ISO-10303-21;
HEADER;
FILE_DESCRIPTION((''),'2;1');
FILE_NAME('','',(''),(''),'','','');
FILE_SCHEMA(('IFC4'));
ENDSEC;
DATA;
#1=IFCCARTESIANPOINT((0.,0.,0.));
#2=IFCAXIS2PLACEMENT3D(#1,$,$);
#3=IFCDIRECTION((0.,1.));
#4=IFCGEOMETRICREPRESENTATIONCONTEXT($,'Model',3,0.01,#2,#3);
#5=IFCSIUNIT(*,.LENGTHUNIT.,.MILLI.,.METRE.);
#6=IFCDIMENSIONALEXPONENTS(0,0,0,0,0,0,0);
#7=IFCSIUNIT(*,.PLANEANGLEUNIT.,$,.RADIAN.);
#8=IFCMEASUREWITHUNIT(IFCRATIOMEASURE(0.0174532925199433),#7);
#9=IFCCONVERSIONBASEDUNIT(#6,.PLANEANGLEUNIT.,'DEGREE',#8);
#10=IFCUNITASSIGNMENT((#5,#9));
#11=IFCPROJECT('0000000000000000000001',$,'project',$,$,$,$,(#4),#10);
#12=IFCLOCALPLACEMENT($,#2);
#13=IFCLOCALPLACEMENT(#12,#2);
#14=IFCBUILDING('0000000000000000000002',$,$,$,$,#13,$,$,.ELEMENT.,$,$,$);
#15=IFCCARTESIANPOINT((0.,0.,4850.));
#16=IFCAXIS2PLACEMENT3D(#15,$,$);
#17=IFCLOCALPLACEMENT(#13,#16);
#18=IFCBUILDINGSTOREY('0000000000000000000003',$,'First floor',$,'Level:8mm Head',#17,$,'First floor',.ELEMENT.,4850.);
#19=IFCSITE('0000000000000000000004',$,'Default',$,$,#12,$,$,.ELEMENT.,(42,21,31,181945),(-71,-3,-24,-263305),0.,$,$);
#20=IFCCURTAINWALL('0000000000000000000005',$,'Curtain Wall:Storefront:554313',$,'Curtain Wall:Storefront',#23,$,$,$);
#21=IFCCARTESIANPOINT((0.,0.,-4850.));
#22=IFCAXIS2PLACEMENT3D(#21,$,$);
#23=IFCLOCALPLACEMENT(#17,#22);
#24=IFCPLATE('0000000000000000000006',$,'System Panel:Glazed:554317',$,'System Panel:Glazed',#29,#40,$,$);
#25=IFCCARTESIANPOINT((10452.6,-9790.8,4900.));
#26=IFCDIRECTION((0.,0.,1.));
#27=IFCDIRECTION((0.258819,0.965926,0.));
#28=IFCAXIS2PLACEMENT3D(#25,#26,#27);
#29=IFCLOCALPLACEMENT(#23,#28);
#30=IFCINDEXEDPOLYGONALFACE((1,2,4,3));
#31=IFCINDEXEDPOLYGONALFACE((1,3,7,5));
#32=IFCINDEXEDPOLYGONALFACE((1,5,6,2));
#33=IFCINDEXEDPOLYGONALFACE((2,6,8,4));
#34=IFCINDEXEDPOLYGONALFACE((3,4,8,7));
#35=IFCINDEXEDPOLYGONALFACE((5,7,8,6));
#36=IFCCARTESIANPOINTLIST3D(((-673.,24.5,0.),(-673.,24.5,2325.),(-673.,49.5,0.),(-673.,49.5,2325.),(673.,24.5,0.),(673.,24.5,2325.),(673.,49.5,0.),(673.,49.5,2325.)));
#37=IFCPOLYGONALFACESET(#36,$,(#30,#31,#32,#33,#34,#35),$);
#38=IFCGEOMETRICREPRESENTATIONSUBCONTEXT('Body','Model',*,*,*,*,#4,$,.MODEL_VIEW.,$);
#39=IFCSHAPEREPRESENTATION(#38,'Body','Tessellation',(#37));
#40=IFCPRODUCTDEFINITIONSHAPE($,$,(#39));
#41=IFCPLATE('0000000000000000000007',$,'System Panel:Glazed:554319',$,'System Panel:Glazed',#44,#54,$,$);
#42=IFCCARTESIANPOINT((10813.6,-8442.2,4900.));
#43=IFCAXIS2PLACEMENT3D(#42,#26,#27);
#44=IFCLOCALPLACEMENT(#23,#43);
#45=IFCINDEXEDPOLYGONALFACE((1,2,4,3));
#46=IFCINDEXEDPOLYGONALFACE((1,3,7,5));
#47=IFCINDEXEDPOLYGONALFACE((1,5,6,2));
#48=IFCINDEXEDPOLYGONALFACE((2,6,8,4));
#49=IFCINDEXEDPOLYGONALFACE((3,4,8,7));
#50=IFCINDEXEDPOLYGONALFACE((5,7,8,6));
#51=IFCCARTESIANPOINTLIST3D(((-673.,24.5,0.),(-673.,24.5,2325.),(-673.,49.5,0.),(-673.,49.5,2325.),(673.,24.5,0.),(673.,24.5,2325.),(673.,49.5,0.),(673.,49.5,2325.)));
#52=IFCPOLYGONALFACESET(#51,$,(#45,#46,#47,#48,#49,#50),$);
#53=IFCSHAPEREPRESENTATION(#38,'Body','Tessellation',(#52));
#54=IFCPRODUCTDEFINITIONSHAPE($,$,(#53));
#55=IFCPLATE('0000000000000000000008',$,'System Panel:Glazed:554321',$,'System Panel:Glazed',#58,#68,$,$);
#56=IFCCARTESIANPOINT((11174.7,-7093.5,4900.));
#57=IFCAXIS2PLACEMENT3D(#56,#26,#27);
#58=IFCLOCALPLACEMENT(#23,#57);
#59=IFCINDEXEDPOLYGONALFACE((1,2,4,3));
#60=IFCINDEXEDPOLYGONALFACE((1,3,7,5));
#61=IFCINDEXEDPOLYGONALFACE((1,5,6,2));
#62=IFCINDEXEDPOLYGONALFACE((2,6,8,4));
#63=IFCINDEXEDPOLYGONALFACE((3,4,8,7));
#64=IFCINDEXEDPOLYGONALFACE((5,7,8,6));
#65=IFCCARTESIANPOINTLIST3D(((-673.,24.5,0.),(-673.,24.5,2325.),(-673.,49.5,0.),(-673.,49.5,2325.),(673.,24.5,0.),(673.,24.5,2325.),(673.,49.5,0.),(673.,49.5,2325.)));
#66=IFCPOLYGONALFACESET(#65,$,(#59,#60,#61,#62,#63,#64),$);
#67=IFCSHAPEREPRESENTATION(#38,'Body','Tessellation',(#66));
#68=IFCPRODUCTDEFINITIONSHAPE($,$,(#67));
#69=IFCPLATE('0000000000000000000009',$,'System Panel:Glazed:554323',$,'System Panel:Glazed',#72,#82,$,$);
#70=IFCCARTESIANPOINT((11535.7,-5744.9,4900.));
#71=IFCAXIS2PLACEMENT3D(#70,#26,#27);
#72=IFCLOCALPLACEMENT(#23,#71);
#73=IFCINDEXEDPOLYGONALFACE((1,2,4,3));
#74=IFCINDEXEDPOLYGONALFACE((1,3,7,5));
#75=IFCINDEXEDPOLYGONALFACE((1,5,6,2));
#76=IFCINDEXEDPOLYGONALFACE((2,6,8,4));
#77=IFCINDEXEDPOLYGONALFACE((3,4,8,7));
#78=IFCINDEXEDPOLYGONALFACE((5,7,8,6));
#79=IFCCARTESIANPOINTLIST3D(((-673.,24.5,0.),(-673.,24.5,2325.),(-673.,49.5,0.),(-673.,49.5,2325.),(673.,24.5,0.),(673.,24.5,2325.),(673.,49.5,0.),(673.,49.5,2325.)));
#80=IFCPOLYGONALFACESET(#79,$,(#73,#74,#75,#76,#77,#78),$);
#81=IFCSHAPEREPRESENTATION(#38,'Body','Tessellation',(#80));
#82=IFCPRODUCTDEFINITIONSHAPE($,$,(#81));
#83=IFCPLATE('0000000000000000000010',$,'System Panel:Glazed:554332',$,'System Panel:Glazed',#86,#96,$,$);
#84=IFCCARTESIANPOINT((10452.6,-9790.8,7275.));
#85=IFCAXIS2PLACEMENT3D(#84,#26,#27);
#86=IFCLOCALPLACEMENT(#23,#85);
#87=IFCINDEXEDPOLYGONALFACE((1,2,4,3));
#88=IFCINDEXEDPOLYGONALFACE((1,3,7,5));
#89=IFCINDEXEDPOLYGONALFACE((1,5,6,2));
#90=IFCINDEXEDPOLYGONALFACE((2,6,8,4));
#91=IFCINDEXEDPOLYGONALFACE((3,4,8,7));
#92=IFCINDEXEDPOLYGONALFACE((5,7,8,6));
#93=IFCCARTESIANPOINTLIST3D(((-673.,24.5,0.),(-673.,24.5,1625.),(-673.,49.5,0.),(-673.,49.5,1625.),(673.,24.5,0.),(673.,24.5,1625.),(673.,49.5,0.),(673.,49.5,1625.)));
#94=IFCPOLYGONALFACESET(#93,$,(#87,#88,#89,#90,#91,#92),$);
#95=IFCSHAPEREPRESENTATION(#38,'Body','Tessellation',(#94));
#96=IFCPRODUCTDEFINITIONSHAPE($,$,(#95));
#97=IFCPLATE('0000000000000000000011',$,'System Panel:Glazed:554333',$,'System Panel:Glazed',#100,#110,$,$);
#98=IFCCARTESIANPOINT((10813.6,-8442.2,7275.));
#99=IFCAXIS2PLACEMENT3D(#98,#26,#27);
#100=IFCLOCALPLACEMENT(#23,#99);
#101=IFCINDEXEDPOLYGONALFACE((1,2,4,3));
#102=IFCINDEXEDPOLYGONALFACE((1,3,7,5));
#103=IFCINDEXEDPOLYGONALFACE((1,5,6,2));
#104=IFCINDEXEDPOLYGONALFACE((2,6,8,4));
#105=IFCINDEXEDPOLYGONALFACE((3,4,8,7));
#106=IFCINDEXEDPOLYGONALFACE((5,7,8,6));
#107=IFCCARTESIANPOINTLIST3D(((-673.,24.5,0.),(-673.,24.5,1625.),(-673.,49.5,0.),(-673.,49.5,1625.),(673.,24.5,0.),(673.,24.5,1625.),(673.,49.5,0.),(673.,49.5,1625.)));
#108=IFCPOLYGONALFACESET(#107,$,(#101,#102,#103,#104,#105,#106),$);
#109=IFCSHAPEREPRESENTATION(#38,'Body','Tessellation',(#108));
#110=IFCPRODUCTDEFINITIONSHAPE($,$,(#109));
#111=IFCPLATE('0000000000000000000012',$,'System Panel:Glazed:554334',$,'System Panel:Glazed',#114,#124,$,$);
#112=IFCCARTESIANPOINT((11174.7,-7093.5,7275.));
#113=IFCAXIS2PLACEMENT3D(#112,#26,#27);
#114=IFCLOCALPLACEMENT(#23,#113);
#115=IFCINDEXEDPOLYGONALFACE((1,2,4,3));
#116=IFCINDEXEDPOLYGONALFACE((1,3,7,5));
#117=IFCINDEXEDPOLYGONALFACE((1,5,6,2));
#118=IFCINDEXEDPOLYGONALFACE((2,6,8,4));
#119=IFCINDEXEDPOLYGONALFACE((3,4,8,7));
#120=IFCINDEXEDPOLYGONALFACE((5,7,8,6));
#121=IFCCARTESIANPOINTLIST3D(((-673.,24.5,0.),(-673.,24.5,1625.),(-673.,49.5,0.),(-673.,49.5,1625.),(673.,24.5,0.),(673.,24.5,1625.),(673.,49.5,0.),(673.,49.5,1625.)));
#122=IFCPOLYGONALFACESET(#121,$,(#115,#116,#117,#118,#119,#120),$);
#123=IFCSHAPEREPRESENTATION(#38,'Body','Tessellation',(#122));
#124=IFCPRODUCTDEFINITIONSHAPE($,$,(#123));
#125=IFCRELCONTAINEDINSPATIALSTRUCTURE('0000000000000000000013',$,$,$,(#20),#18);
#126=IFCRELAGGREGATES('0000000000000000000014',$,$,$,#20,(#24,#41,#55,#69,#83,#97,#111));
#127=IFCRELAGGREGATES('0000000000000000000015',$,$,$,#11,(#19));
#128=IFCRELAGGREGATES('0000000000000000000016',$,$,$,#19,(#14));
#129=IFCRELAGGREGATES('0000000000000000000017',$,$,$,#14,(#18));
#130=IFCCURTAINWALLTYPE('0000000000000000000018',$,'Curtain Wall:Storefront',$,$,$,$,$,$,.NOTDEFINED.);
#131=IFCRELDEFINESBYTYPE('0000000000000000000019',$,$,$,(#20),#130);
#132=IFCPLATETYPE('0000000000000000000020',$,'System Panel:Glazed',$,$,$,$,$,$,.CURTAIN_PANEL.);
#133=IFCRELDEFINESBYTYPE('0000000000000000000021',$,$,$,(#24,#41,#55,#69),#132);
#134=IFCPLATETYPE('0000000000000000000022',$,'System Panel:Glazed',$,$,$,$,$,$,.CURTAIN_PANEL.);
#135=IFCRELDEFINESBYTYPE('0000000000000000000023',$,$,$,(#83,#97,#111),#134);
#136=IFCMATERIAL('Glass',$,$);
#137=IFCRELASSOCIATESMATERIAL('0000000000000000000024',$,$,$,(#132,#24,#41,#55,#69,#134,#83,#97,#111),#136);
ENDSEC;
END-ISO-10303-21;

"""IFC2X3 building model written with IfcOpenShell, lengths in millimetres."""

from ifc_helpers import new_model, entity, si_unit, converted_unit, direction, frame, frame_2d, origin, place, context, subcontext, project, spatial, rectangle, extrude, source, transform, mapped, material, type_object, type_shapes, element, aggregate, save


model = new_model("IFC2X3")

# Units and contexts
model_context = context("Model", 3, precision=0.01, world=origin(), true_north=direction((0.0, 1.0)))
body_context = subcontext(model_context, "Body", "Model", "MODEL_VIEW")
ifc_project = project(units=[si_unit("LENGTHUNIT", "METRE", prefix="MILLI"), converted_unit("PLANEANGLEUNIT", "DEGREE", entity("IfcRatioMeasure", 0.0174532925199433), si_unit("PLANEANGLEUNIT", "RADIAN"), dimensions=[0, 0, 0, 0, 0, 0, 0])], contexts=[model_context])

# Site, building, storey
site_placement = place(None, origin())
site = spatial("IfcSite", under=ifc_project, at=site_placement, Name="Default", CompositionType="ELEMENT", RefLatitude=(42, 21, 31, 181945), RefLongitude=(-71, -3, -24, -263305), RefElevation=0.0)
building_placement = place(site_placement, origin())
building = spatial("IfcBuilding", under=site, at=building_placement, CompositionType="ELEMENT")
storey_placement = place(building_placement, frame((0.0, 0.0, 4850.0)))
storey = spatial("IfcBuildingStorey", under=building, at=storey_placement, Name="First floor", ObjectType="Level:8mm Head", LongName="First floor", CompositionType="ELEMENT", Elevation=4850.0)

# Curtain wall, plates
curtain_wall_type = type_object("IfcCurtainWallType", Name="Curtain Wall:Storefront", PredefinedType="NOTDEFINED")
curtain_wall_placement = place(storey_placement, frame((0.0, 0.0, -4850.0)))
curtain_wall = element("IfcCurtainWall", 1, at=curtain_wall_placement, inside=storey, type_object=curtain_wall_type, Name="Curtain Wall:Storefront:554313", ObjectType="Curtain Wall:Storefront")
ifc_material_1 = material(Name="Glass")
plate_type_1 = type_object("IfcPlateType", Name="System Panel:Glazed", PredefinedType="CURTAIN_PANEL", material=ifc_material_1)
shared_shape_1 = source(origin(), body_context, "Body", "SweptSolid", [
    extrude(rectangle(XDim=25.0, YDim=1346.1, at=frame_2d((0.0, 0.0), x_axis=(1.0, 0.0))), frame((0.0, 37.0, 0.0), z_axis=(0.0, 0.0, 1.0), x_axis=(0.0, 1.0, 0.0)), (0.0, 0.0, 1.0), 2325.0),
])
type_shapes(plate_type_1, [shared_shape_1])
plate_1_placement = place(curtain_wall_placement, frame((10452.6, -9790.8, 4900.0), z_axis=(0.0, 0.0, 1.0), x_axis=(0.258819, 0.965926, 0.0)))
plate_1 = element("IfcPlate", 2, at=plate_1_placement, type_object=plate_type_1, material=ifc_material_1, Name="System Panel:Glazed:554317", ObjectType="System Panel:Glazed", context=body_context, shape_type="MappedRepresentation", body=[
    mapped(shared_shape_1, transform((0.0, 0.0, 0.0), scale=1.0)),
])
plate_2_placement = place(curtain_wall_placement, frame((10813.6, -8442.2, 4900.0), z_axis=(0.0, 0.0, 1.0), x_axis=(0.258819, 0.965926, 0.0)))
plate_2 = element("IfcPlate", 3, at=plate_2_placement, type_object=plate_type_1, material=ifc_material_1, Name="System Panel:Glazed:554319", ObjectType="System Panel:Glazed", context=body_context, shape_type="MappedRepresentation", body=[
    mapped(shared_shape_1, transform((0.0, 0.0, 0.0), scale=1.0)),
])
plate_3_placement = place(curtain_wall_placement, frame((11174.7, -7093.5, 4900.0), z_axis=(0.0, 0.0, 1.0), x_axis=(0.258819, 0.965926, 0.0)))
plate_3 = element("IfcPlate", 4, at=plate_3_placement, type_object=plate_type_1, material=ifc_material_1, Name="System Panel:Glazed:554321", ObjectType="System Panel:Glazed", context=body_context, shape_type="MappedRepresentation", body=[
    mapped(shared_shape_1, transform((0.0, 0.0, 0.0), scale=1.0)),
])
plate_4_placement = place(curtain_wall_placement, frame((11535.7, -5744.9, 4900.0), z_axis=(0.0, 0.0, 1.0), x_axis=(0.258819, 0.965926, 0.0)))
plate_4 = element("IfcPlate", 5, at=plate_4_placement, type_object=plate_type_1, material=ifc_material_1, Name="System Panel:Glazed:554323", ObjectType="System Panel:Glazed", context=body_context, shape_type="MappedRepresentation", body=[
    mapped(shared_shape_1, transform((0.0, 0.0, 0.0), scale=1.0)),
])
plate_type_2 = type_object("IfcPlateType", Name="System Panel:Glazed", PredefinedType="CURTAIN_PANEL", material=ifc_material_1)
shared_shape_2 = source(origin(), body_context, "Body", "SweptSolid", [
    extrude(rectangle(XDim=25.0, YDim=1346.1, at=frame_2d((0.0, 0.0), x_axis=(1.0, 0.0))), frame((0.0, 37.0, 0.0), z_axis=(0.0, 0.0, 1.0), x_axis=(0.0, 1.0, 0.0)), (0.0, 0.0, 1.0), 1625.0),
])
type_shapes(plate_type_2, [shared_shape_2])
plate_5_placement = place(curtain_wall_placement, frame((10452.6, -9790.8, 7275.0), z_axis=(0.0, 0.0, 1.0), x_axis=(0.258819, 0.965926, 0.0)))
plate_5 = element("IfcPlate", 6, at=plate_5_placement, type_object=plate_type_2, material=ifc_material_1, Name="System Panel:Glazed:554332", ObjectType="System Panel:Glazed", context=body_context, shape_type="MappedRepresentation", body=[
    mapped(shared_shape_2, transform((0.0, 0.0, 0.0), scale=1.0)),
])
plate_6_placement = place(curtain_wall_placement, frame((10813.6, -8442.2, 7275.0), z_axis=(0.0, 0.0, 1.0), x_axis=(0.258819, 0.965926, 0.0)))
plate_6 = element("IfcPlate", 7, at=plate_6_placement, type_object=plate_type_2, material=ifc_material_1, Name="System Panel:Glazed:554333", ObjectType="System Panel:Glazed", context=body_context, shape_type="MappedRepresentation", body=[
    mapped(shared_shape_2, transform((0.0, 0.0, 0.0), scale=1.0)),
])
plate_7_placement = place(curtain_wall_placement, frame((11174.7, -7093.5, 7275.0), z_axis=(0.0, 0.0, 1.0), x_axis=(0.258819, 0.965926, 0.0)))
plate_7 = element("IfcPlate", 8, at=plate_7_placement, type_object=plate_type_2, material=ifc_material_1, Name="System Panel:Glazed:554334", ObjectType="System Panel:Glazed", context=body_context, shape_type="MappedRepresentation", body=[
    mapped(shared_shape_2, transform((0.0, 0.0, 0.0), scale=1.0)),
])
aggregate(curtain_wall, [plate_1, plate_2, plate_3, plate_4, plate_5, plate_6, plate_7])

save(model, "model.ifc")
